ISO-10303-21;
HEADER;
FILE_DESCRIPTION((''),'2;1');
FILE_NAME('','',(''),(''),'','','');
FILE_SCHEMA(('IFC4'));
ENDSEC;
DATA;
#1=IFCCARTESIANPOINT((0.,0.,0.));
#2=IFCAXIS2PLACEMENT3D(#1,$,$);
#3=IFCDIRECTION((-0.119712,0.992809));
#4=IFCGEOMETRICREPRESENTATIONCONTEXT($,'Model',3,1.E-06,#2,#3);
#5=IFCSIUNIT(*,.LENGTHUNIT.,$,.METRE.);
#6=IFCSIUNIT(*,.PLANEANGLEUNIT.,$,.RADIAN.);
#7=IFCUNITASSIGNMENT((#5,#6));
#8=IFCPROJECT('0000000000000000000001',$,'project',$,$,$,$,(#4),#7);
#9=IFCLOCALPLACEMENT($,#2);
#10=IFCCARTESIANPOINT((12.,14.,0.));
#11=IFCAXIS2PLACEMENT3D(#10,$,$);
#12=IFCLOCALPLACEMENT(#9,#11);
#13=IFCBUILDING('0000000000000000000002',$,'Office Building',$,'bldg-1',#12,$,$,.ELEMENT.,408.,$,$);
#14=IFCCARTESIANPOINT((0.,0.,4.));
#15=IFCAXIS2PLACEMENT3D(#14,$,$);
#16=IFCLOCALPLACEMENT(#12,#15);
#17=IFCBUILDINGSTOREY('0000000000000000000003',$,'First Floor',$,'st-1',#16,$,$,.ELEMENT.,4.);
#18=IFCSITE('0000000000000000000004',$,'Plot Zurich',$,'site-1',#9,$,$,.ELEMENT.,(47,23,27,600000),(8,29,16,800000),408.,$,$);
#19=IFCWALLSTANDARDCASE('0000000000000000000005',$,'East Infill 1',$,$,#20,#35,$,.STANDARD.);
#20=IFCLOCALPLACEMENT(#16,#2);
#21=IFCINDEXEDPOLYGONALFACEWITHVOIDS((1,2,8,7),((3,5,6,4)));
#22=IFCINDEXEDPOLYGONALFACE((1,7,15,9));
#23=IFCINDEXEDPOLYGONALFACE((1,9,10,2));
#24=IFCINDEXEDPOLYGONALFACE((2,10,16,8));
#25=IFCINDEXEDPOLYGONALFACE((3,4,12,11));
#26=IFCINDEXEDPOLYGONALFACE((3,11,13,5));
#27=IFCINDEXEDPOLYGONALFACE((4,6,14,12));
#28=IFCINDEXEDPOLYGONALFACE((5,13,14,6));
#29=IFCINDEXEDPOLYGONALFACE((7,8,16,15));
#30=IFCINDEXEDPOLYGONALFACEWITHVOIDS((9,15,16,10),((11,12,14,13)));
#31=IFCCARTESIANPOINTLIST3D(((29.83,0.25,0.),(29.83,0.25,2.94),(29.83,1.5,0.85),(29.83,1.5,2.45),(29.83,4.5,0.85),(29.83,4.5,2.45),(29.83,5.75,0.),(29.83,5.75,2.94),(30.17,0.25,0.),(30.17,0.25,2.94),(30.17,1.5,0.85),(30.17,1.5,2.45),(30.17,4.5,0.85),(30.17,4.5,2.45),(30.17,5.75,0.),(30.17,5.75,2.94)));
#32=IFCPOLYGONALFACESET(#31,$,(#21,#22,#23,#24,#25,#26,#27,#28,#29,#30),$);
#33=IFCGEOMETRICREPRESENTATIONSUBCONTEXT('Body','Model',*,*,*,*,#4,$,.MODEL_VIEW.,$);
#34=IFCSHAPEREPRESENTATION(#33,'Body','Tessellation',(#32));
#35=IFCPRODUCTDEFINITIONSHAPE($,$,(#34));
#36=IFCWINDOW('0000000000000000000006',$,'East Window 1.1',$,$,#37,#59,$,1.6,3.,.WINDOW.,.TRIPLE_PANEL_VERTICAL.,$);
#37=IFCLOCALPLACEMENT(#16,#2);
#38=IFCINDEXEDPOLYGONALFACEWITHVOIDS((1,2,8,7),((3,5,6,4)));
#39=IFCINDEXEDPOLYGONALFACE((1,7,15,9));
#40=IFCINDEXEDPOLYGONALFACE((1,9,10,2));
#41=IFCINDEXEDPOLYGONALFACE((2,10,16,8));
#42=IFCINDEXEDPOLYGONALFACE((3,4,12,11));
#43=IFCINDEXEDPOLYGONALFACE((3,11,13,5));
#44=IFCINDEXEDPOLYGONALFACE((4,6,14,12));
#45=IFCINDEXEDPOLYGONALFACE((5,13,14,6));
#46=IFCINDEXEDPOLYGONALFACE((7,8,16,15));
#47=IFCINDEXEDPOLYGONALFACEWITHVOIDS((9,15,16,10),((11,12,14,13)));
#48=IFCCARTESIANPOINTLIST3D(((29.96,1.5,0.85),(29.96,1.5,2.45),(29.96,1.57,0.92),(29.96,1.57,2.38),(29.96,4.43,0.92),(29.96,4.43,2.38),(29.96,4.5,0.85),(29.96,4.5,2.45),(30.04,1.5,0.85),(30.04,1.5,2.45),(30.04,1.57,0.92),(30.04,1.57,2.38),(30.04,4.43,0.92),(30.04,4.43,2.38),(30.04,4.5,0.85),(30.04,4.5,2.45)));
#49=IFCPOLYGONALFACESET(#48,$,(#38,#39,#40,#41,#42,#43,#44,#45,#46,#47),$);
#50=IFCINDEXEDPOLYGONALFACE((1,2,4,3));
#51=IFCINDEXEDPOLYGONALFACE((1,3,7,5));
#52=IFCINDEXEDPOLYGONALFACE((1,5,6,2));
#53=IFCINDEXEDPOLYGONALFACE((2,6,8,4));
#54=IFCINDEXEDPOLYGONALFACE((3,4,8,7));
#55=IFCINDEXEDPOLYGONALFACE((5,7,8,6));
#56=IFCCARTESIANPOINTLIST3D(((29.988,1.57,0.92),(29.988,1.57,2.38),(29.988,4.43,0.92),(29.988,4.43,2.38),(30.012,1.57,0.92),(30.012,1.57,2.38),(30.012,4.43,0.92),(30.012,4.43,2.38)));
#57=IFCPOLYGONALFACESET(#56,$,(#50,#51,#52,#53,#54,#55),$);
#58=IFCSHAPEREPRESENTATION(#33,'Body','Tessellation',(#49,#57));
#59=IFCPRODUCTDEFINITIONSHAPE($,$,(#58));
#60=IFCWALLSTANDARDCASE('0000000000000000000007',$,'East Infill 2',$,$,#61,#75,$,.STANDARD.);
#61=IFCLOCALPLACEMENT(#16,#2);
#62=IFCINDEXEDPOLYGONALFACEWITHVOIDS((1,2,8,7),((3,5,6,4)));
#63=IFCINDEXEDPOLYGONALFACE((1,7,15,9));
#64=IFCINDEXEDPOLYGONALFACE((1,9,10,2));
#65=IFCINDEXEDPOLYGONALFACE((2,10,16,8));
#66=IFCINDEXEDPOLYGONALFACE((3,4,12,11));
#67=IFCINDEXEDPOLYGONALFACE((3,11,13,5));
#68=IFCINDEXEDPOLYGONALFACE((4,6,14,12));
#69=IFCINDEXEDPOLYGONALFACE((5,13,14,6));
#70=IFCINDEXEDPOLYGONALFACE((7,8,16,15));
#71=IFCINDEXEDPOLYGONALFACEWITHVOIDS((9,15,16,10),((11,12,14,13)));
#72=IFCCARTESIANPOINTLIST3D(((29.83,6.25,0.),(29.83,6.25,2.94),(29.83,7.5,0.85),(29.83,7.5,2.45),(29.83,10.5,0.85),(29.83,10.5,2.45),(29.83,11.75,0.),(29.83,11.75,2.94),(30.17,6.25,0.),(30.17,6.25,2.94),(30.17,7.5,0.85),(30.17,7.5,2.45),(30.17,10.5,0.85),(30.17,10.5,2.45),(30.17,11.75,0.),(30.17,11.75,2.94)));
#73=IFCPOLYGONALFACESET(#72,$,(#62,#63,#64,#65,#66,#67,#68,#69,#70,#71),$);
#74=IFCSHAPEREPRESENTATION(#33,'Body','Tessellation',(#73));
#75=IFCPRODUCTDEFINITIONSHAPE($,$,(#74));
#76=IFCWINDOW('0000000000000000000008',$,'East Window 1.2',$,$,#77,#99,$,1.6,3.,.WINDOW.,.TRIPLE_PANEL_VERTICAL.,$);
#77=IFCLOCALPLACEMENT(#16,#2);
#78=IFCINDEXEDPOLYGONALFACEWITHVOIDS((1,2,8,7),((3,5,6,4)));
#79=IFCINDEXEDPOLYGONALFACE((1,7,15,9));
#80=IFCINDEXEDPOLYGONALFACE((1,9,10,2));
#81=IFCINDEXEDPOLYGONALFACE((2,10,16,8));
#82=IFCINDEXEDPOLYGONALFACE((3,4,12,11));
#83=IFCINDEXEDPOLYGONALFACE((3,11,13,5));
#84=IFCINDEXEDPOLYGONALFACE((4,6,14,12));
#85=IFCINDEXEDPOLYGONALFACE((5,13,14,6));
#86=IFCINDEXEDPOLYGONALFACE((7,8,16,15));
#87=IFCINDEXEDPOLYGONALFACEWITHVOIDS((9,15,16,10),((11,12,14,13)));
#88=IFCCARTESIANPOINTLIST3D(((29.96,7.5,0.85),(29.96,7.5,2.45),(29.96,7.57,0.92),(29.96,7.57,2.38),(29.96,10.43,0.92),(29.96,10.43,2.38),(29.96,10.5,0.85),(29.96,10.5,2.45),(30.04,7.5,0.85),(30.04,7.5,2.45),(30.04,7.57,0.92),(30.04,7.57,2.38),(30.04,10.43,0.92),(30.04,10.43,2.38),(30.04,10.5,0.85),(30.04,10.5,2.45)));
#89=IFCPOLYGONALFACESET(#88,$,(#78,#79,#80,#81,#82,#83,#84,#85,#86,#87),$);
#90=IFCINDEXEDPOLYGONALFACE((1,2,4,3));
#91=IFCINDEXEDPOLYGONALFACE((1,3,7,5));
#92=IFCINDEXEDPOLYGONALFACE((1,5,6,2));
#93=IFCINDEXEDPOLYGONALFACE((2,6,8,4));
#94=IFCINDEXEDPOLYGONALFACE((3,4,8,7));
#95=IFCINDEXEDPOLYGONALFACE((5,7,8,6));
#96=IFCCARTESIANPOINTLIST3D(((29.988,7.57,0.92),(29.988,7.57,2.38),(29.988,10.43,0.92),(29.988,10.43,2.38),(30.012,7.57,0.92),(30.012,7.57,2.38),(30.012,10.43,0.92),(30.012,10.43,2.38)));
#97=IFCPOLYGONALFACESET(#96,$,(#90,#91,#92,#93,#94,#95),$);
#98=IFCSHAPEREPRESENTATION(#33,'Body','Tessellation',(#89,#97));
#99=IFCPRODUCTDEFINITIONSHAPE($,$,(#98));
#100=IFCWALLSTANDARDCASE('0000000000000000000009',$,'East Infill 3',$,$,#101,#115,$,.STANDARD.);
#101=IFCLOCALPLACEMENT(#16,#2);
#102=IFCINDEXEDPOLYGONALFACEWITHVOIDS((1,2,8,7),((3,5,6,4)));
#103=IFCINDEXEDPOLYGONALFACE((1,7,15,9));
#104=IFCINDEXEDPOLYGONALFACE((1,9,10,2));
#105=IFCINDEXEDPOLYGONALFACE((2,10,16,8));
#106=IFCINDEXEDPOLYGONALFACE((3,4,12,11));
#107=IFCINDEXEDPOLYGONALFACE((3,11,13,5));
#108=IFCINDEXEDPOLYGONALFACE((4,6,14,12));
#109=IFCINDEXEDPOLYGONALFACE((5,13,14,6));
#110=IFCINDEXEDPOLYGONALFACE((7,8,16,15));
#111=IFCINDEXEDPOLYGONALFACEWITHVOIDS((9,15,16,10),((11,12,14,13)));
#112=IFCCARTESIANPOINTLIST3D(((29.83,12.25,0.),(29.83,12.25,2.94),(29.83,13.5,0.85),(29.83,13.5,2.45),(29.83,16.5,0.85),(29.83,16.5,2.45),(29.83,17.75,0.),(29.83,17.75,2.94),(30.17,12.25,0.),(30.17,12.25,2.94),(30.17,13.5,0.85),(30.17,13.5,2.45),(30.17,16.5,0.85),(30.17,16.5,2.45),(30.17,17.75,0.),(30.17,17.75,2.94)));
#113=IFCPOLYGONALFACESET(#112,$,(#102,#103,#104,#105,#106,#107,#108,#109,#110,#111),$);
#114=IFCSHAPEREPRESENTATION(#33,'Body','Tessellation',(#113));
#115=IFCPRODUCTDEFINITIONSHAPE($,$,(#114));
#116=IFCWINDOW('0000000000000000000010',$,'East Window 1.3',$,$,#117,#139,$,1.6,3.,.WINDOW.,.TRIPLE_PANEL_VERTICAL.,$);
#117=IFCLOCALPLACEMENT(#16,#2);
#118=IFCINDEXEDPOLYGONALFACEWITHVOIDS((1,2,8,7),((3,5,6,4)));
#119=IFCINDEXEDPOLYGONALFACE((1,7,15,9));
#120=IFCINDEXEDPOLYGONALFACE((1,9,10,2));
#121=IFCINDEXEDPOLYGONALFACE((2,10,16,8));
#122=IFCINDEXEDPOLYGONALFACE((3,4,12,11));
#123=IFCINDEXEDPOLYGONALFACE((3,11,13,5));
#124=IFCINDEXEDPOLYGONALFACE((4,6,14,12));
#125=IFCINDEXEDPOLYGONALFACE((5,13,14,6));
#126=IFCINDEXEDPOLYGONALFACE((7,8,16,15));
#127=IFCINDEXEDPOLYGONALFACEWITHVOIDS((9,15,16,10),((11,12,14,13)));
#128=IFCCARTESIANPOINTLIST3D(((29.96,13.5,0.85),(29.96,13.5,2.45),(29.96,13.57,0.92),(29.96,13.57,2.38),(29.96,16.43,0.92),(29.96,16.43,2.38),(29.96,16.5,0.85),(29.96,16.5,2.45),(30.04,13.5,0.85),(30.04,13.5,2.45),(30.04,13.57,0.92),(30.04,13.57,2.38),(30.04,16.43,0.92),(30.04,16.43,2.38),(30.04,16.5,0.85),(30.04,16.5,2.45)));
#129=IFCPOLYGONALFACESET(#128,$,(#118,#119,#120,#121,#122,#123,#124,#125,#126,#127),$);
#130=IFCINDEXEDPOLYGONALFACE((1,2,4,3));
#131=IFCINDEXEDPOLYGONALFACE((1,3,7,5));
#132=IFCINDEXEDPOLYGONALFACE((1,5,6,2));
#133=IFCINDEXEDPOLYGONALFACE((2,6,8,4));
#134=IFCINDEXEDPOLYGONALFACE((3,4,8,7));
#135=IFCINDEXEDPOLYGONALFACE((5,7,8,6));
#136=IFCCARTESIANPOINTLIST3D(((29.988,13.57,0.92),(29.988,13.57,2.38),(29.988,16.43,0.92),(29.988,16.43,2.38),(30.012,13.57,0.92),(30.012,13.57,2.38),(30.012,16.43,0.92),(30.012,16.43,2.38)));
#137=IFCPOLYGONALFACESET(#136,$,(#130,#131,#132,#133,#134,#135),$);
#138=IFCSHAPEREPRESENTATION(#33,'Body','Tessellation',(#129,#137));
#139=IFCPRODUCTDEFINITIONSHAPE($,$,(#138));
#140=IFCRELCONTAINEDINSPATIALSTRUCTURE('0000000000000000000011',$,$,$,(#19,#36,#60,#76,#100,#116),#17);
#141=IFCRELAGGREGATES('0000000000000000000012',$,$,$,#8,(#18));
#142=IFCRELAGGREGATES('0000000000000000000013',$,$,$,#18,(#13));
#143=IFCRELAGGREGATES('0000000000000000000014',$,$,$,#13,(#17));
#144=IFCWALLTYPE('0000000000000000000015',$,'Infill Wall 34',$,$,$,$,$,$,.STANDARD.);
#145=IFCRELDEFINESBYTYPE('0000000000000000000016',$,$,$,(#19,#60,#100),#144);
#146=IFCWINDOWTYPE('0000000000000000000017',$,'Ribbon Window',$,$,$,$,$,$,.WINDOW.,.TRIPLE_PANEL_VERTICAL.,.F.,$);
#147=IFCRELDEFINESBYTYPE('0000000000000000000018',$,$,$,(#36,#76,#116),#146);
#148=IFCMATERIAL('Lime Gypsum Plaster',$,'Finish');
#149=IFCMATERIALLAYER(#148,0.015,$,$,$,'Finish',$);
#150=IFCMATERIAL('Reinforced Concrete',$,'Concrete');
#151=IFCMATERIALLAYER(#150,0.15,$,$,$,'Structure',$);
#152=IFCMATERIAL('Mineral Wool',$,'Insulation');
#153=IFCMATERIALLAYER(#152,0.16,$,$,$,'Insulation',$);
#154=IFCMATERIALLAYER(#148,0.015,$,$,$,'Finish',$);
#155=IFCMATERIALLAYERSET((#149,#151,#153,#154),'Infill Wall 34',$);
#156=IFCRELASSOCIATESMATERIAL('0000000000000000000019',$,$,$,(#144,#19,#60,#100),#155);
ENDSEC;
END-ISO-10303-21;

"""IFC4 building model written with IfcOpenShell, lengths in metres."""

from ifc_helpers import new_model, si_unit, direction, frame, frame_2d, origin, origin_2d, place, context, subcontext, project, spatial, polyline, rectangle, outline, extrude, material, layer, layer_set, layer_usage, type_object, element, fill, save


model = new_model("IFC4")

# Units and contexts
model_context = context("Model", 3, precision=1e-06, world=origin(), true_north=direction((-0.119712, 0.992809)))
body_context = subcontext(model_context, "Body", "Model", "MODEL_VIEW")
ifc_project = project(units=[si_unit("LENGTHUNIT", "METRE"), si_unit("PLANEANGLEUNIT", "RADIAN")], contexts=[model_context])

# Site, building, storey
site_placement = place(None, origin())
site = spatial("IfcSite", under=ifc_project, at=site_placement, Name="Plot Zurich", ObjectType="site-1", CompositionType="ELEMENT", RefLatitude=(47, 23, 27, 600000), RefLongitude=(8, 29, 16, 800000), RefElevation=408.0)
building_placement = place(site_placement, frame((12.0, 14.0, 0.0)))
building = spatial("IfcBuilding", under=site, at=building_placement, Name="Office Building", ObjectType="bldg-1", CompositionType="ELEMENT", ElevationOfRefHeight=408.0)
storey_placement = place(building_placement, frame((0.0, 0.0, 4.0)))
storey = spatial("IfcBuildingStorey", under=building, at=storey_placement, Name="First Floor", ObjectType="st-1", CompositionType="ELEMENT", Elevation=4.0)

# Shared definitions
ifc_material_1 = material(Name="Reinforced Concrete", Category="Concrete")

# Walls, openings, windows
ifc_material_2 = material(Name="Lime Gypsum Plaster", Category="Finish")
ifc_layer_1 = layer(ifc_material_2, 0.015, Category="Finish")
ifc_layer_2 = layer(ifc_material_1, 0.15, Category="Structure")
ifc_material_3 = material(Name="Mineral Wool", Category="Insulation")
ifc_layer_3 = layer(ifc_material_3, 0.16, Category="Insulation")
ifc_layer_4 = layer(ifc_material_2, 0.015, Category="Finish")
ifc_layer_set = layer_set([ifc_layer_1, ifc_layer_2, ifc_layer_3, ifc_layer_4], Name="Infill Wall 34")
ifc_layer_usage_1 = layer_usage(ifc_layer_set, "AXIS2", "NEGATIVE", 0.17)
wall_type = type_object("IfcWallType", Name="Infill Wall 34", PredefinedType="STANDARD", material=ifc_layer_set)
wall_1_placement = place(storey_placement, frame((30.0, 0.25, 0.0), z_axis=(0.0, 0.0, 1.0), x_axis=(0.0, 1.0, 0.0)))
wall_1 = element("IfcWallStandardCase", 1, at=wall_1_placement, inside=storey, type_object=wall_type, material=ifc_layer_usage_1, Name="East Infill 1", PredefinedType="STANDARD", context=body_context, shape_type="SweptSolid", body=[
    extrude(rectangle(XDim=5.5, YDim=0.34, at=frame_2d((2.75, 0.0))), origin(), (0.0, 0.0, 1.0), 2.94),
])
opening_1_placement = place(wall_1_placement, frame((2.75, 0.0, 0.85)))
opening_1 = element("IfcOpeningElement", 2, at=opening_1_placement, cuts=wall_1, PredefinedType="OPENING", context=body_context, shape_type="SweptSolid", body=[
    extrude(rectangle(XDim=3.0, YDim=0.34, at=origin_2d()), origin(), (0.0, 0.0, 1.0), 1.6),
])
window_type = type_object("IfcWindowType", Name="Ribbon Window", ParameterTakesPrecedence=False, PartitioningType="TRIPLE_PANEL_VERTICAL", PredefinedType="WINDOW")
window_1_placement = place(opening_1_placement, frame((0.0, 0.0, 0.0), z_axis=(0.0, 1.0, 0.0), x_axis=(-1.0, 0.0, 0.0)))
window_1 = element("IfcWindow", 3, at=window_1_placement, inside=storey, type_object=window_type, Name="East Window 1.1", OverallHeight=1.6, OverallWidth=3.0, PartitioningType="TRIPLE_PANEL_VERTICAL", PredefinedType="WINDOW", context=body_context, shape_type="SweptSolid", body=[
    extrude(outline(polyline([(-1.5, 0.0), (1.5, 0.0), (1.5, 1.6), (-1.5, 1.6), (-1.5, 0.0)]), holes=[polyline([(-1.43, 0.07), (1.43, 0.07), (1.43, 1.53), (-1.43, 1.53), (-1.43, 0.07)])]), frame((0.0, 0.0, -0.04)), (0.0, 0.0, 1.0), 0.08),
    extrude(rectangle(XDim=2.86, YDim=1.46, at=frame_2d((0.0, 0.8))), frame((0.0, 0.0, -0.012)), (0.0, 0.0, 1.0), 0.024),
])
fill(opening_1, window_1)
ifc_layer_usage_2 = layer_usage(ifc_layer_set, "AXIS2", "NEGATIVE", 0.17)
wall_2_placement = place(storey_placement, frame((30.0, 6.25, 0.0), z_axis=(0.0, 0.0, 1.0), x_axis=(0.0, 1.0, 0.0)))
wall_2 = element("IfcWallStandardCase", 4, at=wall_2_placement, inside=storey, type_object=wall_type, material=ifc_layer_usage_2, Name="East Infill 2", PredefinedType="STANDARD", context=body_context, shape_type="SweptSolid", body=[
    extrude(rectangle(XDim=5.5, YDim=0.34, at=frame_2d((2.75, 0.0))), origin(), (0.0, 0.0, 1.0), 2.94),
])
opening_2_placement = place(wall_2_placement, frame((2.75, 0.0, 0.85)))
opening_2 = element("IfcOpeningElement", 5, at=opening_2_placement, cuts=wall_2, PredefinedType="OPENING", context=body_context, shape_type="SweptSolid", body=[
    extrude(rectangle(XDim=3.0, YDim=0.34, at=origin_2d()), origin(), (0.0, 0.0, 1.0), 1.6),
])
window_2_placement = place(opening_2_placement, frame((0.0, 0.0, 0.0), z_axis=(0.0, 1.0, 0.0), x_axis=(-1.0, 0.0, 0.0)))
window_2 = element("IfcWindow", 6, at=window_2_placement, inside=storey, type_object=window_type, Name="East Window 1.2", OverallHeight=1.6, OverallWidth=3.0, PartitioningType="TRIPLE_PANEL_VERTICAL", PredefinedType="WINDOW", context=body_context, shape_type="SweptSolid", body=[
    extrude(outline(polyline([(-1.5, 0.0), (1.5, 0.0), (1.5, 1.6), (-1.5, 1.6), (-1.5, 0.0)]), holes=[polyline([(-1.43, 0.07), (1.43, 0.07), (1.43, 1.53), (-1.43, 1.53), (-1.43, 0.07)])]), frame((0.0, 0.0, -0.04)), (0.0, 0.0, 1.0), 0.08),
    extrude(rectangle(XDim=2.86, YDim=1.46, at=frame_2d((0.0, 0.8))), frame((0.0, 0.0, -0.012)), (0.0, 0.0, 1.0), 0.024),
])
fill(opening_2, window_2)
ifc_layer_usage_3 = layer_usage(ifc_layer_set, "AXIS2", "NEGATIVE", 0.17)
wall_3_placement = place(storey_placement, frame((30.0, 12.25, 0.0), z_axis=(0.0, 0.0, 1.0), x_axis=(0.0, 1.0, 0.0)))
wall_3 = element("IfcWallStandardCase", 7, at=wall_3_placement, inside=storey, type_object=wall_type, material=ifc_layer_usage_3, Name="East Infill 3", PredefinedType="STANDARD", context=body_context, shape_type="SweptSolid", body=[
    extrude(rectangle(XDim=5.5, YDim=0.34, at=frame_2d((2.75, 0.0))), origin(), (0.0, 0.0, 1.0), 2.94),
])
opening_3_placement = place(wall_3_placement, frame((2.75, 0.0, 0.85)))
opening_3 = element("IfcOpeningElement", 8, at=opening_3_placement, cuts=wall_3, PredefinedType="OPENING", context=body_context, shape_type="SweptSolid", body=[
    extrude(rectangle(XDim=3.0, YDim=0.34, at=origin_2d()), origin(), (0.0, 0.0, 1.0), 1.6),
])
window_3_placement = place(opening_3_placement, frame((0.0, 0.0, 0.0), z_axis=(0.0, 1.0, 0.0), x_axis=(-1.0, 0.0, 0.0)))
window_3 = element("IfcWindow", 9, at=window_3_placement, inside=storey, type_object=window_type, Name="East Window 1.3", OverallHeight=1.6, OverallWidth=3.0, PartitioningType="TRIPLE_PANEL_VERTICAL", PredefinedType="WINDOW", context=body_context, shape_type="SweptSolid", body=[
    extrude(outline(polyline([(-1.5, 0.0), (1.5, 0.0), (1.5, 1.6), (-1.5, 1.6), (-1.5, 0.0)]), holes=[polyline([(-1.43, 0.07), (1.43, 0.07), (1.43, 1.53), (-1.43, 1.53), (-1.43, 0.07)])]), frame((0.0, 0.0, -0.04)), (0.0, 0.0, 1.0), 0.08),
    extrude(rectangle(XDim=2.86, YDim=1.46, at=frame_2d((0.0, 0.8))), frame((0.0, 0.0, -0.012)), (0.0, 0.0, 1.0), 0.024),
])
fill(opening_3, window_3)

save(model, "model.ifc")
